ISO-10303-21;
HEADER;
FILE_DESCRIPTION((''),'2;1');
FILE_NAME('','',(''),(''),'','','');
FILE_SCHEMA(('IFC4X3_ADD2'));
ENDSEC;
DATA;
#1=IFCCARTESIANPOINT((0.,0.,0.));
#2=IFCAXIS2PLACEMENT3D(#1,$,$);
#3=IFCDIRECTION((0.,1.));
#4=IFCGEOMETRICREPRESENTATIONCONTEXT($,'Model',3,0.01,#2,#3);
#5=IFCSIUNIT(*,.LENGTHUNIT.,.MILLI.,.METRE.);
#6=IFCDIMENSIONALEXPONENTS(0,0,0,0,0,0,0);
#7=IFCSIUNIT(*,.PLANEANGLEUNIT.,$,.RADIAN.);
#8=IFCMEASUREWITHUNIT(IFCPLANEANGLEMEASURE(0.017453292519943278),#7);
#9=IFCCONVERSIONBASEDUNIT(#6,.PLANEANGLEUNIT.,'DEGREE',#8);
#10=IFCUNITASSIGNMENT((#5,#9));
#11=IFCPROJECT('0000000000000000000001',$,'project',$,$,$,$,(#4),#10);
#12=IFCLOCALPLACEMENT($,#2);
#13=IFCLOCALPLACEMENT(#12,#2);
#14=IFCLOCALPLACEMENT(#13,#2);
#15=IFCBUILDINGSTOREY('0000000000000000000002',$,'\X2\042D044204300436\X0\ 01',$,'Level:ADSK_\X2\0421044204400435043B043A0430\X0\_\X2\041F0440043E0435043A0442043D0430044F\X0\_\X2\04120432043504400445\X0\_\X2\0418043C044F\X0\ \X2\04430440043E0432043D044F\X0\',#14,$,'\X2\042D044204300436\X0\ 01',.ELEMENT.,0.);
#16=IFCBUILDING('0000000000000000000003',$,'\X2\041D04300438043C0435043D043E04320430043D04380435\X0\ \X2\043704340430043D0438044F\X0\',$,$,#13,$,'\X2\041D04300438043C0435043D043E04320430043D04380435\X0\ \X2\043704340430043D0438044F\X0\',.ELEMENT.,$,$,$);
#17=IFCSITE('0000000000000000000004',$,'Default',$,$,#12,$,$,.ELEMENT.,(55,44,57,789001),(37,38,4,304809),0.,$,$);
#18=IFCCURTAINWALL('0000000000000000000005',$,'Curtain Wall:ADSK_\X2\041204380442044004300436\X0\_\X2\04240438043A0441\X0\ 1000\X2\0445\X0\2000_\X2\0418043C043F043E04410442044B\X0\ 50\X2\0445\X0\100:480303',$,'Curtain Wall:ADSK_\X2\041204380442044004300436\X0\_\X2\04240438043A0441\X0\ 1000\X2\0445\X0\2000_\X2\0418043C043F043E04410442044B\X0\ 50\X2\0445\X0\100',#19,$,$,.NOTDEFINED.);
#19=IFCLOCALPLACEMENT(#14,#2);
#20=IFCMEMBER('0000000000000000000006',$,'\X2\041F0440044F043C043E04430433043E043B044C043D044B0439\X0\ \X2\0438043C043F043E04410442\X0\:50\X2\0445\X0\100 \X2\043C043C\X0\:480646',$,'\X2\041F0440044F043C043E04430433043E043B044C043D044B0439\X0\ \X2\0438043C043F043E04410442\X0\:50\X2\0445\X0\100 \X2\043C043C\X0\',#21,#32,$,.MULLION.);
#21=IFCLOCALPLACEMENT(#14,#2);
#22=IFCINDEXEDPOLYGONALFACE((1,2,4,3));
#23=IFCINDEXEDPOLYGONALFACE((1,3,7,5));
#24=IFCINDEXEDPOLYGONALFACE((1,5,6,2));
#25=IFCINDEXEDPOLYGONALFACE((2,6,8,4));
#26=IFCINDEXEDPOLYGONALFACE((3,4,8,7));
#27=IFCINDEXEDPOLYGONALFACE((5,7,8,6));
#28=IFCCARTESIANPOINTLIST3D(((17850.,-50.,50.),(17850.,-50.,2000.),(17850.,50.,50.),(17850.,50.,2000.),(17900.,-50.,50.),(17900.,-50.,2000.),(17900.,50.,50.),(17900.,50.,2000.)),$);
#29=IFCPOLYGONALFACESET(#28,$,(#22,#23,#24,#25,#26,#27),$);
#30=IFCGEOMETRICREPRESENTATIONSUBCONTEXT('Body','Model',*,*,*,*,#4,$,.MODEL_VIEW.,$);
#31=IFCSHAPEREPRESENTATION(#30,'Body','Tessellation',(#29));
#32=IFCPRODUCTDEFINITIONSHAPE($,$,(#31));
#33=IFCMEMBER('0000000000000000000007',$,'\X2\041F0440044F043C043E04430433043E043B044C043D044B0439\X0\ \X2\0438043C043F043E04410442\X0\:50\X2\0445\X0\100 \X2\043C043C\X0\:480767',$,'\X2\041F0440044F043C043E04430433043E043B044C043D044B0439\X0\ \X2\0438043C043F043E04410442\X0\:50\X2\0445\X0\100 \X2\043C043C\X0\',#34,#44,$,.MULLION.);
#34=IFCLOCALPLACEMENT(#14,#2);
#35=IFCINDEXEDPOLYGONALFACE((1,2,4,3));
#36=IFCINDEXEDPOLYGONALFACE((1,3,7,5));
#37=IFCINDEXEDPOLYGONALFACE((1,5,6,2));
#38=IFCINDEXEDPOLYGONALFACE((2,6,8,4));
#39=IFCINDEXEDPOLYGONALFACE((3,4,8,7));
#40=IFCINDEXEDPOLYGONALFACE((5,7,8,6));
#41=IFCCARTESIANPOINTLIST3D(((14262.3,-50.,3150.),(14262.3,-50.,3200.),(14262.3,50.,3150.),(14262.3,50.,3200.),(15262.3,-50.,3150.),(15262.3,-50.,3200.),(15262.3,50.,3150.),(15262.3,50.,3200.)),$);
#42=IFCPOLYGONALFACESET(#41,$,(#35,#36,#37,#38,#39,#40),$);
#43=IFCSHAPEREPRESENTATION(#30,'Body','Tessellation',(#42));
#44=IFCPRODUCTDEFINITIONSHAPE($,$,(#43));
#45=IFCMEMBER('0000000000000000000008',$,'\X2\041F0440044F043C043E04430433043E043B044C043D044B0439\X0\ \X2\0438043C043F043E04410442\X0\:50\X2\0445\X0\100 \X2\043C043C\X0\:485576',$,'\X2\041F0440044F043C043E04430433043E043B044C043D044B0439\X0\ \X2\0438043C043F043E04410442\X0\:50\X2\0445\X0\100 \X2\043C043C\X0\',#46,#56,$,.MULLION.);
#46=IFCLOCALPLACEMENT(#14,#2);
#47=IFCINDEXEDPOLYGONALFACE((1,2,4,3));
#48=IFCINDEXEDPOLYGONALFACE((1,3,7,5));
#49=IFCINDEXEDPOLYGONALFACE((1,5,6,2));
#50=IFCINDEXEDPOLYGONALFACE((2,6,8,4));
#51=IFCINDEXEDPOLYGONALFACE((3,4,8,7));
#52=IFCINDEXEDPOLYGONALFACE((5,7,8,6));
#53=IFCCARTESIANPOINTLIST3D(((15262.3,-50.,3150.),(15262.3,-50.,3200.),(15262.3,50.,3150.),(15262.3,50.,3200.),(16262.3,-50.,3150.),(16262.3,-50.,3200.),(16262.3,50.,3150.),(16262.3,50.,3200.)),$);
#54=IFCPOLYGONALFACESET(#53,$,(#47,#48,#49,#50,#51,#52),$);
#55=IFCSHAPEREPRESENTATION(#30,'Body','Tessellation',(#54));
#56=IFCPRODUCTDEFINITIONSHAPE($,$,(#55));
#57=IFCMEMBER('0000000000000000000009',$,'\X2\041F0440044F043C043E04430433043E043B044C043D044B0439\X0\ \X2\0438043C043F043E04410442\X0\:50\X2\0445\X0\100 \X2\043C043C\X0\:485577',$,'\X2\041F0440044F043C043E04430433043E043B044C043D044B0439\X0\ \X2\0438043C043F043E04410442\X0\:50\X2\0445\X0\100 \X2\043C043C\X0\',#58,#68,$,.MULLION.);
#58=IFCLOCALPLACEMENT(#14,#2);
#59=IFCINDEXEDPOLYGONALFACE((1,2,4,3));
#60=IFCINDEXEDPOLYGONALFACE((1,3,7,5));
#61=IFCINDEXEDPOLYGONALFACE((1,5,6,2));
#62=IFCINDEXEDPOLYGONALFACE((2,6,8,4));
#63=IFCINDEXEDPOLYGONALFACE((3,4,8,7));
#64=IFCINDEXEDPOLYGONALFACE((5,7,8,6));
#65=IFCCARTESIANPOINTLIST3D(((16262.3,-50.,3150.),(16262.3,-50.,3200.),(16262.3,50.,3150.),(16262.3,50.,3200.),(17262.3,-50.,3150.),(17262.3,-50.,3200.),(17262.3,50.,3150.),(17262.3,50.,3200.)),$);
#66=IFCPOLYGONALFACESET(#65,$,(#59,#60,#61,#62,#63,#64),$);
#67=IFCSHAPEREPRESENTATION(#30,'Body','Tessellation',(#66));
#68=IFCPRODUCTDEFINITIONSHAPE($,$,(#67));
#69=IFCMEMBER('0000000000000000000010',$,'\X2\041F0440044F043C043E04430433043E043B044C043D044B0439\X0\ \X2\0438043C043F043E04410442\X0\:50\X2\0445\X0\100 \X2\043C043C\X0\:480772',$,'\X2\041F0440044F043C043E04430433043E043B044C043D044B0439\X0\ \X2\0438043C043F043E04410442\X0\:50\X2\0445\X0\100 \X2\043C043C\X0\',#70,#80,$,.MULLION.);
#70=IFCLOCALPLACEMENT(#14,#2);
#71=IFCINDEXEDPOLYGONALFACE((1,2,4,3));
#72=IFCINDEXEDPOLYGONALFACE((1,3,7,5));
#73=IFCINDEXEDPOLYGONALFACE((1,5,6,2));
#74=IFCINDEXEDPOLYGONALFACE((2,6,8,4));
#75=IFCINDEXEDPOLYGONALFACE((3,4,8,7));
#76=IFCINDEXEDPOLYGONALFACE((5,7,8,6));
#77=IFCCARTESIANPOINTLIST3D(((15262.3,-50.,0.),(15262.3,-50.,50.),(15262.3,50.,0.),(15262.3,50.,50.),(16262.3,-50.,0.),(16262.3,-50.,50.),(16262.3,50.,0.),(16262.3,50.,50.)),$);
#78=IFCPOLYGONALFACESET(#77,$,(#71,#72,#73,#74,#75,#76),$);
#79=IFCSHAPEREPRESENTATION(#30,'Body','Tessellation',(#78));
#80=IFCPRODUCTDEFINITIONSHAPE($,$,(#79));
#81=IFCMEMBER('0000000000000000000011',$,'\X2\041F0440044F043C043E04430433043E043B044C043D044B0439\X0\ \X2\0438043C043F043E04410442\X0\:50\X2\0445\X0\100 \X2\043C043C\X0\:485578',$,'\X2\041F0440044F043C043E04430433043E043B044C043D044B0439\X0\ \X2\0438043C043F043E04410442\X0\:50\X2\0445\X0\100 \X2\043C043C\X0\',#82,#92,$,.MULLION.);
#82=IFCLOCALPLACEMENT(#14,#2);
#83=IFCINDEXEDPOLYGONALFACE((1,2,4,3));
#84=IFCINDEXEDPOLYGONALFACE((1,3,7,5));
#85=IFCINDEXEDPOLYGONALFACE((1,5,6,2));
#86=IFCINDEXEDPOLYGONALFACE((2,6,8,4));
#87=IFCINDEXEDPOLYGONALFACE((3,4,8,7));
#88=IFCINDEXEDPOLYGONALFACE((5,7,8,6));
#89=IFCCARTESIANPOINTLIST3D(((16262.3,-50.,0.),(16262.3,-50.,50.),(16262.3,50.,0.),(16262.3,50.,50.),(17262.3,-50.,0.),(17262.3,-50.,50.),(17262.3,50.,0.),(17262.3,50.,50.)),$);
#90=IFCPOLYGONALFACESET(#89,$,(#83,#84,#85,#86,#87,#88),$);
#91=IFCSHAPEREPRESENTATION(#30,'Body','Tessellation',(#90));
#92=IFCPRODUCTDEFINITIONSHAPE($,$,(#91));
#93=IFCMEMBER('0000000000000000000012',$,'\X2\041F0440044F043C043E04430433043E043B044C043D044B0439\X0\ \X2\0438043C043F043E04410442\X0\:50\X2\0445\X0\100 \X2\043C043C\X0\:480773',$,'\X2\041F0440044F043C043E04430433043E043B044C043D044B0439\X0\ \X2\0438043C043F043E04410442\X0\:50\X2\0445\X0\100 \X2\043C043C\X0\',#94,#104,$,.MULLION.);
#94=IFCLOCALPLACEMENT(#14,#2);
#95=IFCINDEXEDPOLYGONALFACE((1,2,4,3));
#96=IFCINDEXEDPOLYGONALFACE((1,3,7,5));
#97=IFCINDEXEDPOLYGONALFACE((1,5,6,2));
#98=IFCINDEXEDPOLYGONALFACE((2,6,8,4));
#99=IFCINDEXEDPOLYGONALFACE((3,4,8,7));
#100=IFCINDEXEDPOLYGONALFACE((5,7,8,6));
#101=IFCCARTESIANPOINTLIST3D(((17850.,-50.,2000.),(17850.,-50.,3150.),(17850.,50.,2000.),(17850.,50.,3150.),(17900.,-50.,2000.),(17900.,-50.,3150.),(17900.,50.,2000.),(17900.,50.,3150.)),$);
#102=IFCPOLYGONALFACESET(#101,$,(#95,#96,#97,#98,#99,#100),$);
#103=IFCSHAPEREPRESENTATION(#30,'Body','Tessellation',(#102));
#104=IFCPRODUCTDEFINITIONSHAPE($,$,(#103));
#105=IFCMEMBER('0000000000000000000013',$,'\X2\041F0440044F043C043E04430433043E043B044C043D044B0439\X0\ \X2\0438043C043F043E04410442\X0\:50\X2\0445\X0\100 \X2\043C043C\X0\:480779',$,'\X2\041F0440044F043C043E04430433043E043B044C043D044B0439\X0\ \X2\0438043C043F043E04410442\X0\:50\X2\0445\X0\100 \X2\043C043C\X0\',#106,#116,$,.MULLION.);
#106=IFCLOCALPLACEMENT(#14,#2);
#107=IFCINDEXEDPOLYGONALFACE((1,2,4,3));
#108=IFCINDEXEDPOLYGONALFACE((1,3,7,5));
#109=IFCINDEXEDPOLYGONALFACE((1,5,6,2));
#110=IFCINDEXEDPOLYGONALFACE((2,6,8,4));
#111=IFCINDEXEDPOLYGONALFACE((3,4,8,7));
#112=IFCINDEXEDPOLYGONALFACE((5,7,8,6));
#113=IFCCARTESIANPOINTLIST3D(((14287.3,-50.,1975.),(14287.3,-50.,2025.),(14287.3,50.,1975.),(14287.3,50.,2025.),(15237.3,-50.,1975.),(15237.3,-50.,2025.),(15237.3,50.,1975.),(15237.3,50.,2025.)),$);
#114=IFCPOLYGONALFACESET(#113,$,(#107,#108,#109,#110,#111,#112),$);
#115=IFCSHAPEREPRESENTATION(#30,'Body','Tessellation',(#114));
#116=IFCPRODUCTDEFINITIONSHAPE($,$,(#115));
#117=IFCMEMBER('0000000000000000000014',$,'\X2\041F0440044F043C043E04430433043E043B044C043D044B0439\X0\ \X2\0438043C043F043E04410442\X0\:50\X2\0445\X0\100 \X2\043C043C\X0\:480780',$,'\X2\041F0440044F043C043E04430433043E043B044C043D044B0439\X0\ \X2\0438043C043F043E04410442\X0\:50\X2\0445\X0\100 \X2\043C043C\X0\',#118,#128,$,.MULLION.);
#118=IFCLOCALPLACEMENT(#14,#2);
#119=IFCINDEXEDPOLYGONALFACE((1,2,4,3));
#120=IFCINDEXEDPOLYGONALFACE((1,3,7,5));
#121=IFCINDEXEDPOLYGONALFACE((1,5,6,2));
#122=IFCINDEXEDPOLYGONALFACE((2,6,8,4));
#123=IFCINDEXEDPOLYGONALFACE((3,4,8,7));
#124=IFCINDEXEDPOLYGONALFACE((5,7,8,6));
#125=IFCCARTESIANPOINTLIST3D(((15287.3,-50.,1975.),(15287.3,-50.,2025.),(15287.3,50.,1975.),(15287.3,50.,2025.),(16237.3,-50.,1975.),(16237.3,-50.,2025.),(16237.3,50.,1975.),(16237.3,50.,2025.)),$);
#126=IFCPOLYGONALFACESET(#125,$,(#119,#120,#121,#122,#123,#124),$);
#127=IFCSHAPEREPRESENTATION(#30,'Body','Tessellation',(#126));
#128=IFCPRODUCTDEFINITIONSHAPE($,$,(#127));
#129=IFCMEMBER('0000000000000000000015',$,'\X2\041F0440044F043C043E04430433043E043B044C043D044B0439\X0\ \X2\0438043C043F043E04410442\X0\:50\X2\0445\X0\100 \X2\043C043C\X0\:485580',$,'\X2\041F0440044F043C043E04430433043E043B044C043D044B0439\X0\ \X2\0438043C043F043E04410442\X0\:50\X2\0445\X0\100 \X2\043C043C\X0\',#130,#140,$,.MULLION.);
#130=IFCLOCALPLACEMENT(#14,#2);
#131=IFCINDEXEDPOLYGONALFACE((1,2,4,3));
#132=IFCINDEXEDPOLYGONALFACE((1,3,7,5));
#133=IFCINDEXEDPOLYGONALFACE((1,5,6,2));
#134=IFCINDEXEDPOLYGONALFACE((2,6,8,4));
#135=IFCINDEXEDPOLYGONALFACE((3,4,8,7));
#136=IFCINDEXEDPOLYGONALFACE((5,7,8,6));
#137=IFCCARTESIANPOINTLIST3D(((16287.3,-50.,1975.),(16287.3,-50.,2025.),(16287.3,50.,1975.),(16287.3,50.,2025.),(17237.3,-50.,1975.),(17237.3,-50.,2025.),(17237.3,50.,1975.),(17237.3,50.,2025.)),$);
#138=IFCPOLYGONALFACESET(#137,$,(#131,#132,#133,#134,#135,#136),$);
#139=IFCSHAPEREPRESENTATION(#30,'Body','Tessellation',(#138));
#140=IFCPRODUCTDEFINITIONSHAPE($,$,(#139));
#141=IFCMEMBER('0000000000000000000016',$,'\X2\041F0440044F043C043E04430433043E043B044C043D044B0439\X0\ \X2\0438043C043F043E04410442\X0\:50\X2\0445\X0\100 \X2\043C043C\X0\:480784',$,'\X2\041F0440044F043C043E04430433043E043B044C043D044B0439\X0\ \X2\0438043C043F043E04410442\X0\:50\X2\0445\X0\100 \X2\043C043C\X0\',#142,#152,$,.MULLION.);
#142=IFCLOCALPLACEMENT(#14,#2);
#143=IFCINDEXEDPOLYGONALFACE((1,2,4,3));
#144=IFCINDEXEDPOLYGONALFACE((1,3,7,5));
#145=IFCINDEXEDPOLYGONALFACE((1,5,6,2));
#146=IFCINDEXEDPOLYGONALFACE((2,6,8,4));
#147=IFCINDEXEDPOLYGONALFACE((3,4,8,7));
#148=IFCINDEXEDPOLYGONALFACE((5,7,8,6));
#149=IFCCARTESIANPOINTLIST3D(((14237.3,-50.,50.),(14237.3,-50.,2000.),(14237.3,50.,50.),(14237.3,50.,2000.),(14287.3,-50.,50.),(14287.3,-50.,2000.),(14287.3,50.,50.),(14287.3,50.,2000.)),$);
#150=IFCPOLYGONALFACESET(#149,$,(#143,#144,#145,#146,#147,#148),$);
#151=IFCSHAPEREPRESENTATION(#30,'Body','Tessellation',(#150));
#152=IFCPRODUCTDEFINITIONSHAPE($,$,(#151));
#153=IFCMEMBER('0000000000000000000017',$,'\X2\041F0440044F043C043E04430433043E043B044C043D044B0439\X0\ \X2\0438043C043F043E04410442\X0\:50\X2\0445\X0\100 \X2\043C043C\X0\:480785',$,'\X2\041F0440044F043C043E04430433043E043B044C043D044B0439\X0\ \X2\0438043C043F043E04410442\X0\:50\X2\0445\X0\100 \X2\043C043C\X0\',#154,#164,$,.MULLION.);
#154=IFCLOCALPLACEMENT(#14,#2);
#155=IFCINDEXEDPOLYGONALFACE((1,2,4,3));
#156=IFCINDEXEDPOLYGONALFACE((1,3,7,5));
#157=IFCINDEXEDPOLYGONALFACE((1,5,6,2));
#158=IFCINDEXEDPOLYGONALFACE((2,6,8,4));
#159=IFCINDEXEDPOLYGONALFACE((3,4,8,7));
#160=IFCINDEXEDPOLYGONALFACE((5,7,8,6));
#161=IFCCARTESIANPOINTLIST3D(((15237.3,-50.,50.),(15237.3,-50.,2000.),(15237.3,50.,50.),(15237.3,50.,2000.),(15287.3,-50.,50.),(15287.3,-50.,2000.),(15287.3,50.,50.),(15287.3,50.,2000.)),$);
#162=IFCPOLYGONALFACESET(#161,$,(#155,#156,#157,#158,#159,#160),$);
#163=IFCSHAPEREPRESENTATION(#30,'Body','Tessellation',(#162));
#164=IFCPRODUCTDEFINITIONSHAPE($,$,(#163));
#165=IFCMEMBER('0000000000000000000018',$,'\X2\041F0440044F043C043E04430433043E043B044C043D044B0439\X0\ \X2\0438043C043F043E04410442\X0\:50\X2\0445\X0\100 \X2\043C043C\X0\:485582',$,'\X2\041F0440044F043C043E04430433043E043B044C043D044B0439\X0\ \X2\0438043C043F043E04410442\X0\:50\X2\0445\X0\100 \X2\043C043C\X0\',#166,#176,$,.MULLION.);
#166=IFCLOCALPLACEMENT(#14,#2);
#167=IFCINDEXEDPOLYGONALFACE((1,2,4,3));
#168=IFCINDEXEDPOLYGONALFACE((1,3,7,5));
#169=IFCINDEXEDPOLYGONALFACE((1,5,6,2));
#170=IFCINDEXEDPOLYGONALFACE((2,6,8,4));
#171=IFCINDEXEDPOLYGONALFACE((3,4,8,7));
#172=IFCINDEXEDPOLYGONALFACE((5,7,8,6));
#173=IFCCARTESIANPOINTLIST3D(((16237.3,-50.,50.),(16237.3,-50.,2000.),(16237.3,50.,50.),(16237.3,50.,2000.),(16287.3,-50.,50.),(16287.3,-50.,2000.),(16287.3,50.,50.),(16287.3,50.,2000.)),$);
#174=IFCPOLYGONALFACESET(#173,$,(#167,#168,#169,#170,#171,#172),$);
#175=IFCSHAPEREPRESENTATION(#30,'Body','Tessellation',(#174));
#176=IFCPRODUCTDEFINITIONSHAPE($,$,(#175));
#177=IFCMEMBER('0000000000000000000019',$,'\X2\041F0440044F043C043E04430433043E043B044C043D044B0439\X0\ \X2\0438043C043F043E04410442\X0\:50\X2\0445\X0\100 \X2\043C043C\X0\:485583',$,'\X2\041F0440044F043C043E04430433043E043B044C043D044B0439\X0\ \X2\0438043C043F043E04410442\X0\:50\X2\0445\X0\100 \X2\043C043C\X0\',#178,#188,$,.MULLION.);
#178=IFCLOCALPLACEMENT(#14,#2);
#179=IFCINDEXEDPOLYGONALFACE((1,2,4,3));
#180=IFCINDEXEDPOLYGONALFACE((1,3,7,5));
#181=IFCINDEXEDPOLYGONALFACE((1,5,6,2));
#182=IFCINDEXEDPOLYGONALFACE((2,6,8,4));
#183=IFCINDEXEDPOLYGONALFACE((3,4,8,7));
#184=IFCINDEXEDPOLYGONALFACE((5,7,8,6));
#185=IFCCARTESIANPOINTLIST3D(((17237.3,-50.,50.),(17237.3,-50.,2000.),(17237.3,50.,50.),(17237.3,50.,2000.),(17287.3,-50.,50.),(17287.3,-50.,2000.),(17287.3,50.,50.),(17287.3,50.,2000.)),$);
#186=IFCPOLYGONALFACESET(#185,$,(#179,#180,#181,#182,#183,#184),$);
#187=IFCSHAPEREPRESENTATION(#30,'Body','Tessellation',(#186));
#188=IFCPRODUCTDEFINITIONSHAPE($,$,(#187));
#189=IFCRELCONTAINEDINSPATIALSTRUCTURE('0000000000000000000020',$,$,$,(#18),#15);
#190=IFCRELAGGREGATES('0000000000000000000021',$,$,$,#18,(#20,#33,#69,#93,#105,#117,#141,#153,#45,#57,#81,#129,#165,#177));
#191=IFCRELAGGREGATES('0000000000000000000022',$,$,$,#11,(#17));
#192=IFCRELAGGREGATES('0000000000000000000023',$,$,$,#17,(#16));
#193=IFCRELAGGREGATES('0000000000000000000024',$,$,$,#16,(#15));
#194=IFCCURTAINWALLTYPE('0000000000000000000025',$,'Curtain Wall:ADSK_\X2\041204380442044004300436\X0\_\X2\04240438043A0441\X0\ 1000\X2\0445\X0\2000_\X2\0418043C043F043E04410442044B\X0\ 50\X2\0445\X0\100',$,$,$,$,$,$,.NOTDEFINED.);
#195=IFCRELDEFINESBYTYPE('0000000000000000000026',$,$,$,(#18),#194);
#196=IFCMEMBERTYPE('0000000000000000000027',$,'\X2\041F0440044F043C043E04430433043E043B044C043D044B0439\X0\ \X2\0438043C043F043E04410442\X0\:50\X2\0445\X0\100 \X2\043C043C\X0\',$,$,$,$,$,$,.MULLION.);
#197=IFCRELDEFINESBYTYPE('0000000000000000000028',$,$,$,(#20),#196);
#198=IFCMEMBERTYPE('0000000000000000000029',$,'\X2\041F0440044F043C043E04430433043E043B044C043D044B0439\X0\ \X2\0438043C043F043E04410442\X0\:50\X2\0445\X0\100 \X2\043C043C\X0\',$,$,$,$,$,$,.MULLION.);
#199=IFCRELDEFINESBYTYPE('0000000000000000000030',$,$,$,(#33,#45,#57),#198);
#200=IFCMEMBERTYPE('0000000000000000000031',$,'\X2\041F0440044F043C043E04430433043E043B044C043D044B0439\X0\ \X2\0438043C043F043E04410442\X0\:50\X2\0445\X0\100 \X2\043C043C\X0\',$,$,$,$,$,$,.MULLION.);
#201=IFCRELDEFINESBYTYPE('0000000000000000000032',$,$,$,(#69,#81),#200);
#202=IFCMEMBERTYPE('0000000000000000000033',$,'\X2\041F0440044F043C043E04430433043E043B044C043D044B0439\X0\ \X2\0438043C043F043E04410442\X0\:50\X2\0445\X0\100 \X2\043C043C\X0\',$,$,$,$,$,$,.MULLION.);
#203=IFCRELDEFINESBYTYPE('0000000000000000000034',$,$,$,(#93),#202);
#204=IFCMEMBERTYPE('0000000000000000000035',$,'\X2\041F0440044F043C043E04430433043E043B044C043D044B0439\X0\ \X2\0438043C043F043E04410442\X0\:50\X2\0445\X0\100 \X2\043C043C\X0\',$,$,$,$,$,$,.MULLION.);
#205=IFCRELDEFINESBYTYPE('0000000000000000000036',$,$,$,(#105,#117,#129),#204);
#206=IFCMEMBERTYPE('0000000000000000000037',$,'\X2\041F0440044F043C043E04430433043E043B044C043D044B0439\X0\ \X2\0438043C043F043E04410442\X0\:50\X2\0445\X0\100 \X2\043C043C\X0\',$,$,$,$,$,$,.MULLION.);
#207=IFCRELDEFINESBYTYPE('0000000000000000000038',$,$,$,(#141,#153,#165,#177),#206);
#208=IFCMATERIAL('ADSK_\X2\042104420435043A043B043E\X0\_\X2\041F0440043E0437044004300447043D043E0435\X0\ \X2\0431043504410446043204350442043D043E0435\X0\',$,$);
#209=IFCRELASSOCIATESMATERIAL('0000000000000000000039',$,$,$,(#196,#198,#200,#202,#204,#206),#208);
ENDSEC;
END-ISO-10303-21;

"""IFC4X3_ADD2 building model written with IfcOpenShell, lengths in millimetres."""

from ifc_helpers import new_model, entity, si_unit, converted_unit, direction, frame, frame_2d, origin, place, context, subcontext, project, spatial, rectangle, extrude, source, transform, mapped, material, material_profile, profile_set, type_object, type_shapes, element, aggregate, save


model = new_model("IFC4X3_ADD2")

# Units and contexts
model_context = context("Model", 3, precision=0.01, world=origin(), true_north=direction((0.0, 1.0)))
body_context = subcontext(model_context, "Body", "Model", "MODEL_VIEW")
ifc_project = project(units=[si_unit("LENGTHUNIT", "METRE", prefix="MILLI"), converted_unit("PLANEANGLEUNIT", "DEGREE", entity("IfcPlaneAngleMeasure", 0.017453292519943278), si_unit("PLANEANGLEUNIT", "RADIAN"), dimensions=[0, 0, 0, 0, 0, 0, 0])], contexts=[model_context])

# Site, building, storey
site_placement = place(None, origin())
site = spatial("IfcSite", under=ifc_project, at=site_placement, Name="Default", CompositionType="ELEMENT", RefLatitude=(55, 44, 57, 789001), RefLongitude=(37, 38, 4, 304809), RefElevation=0.0)
building_placement = place(site_placement, origin())
building = spatial("IfcBuilding", under=site, at=building_placement, Name="Наименование здания", LongName="Наименование здания", CompositionType="ELEMENT")
storey_placement = place(building_placement, origin())
storey = spatial("IfcBuildingStorey", under=building, at=storey_placement, Name="Этаж 01", ObjectType="Level:ADSK_Стрелка_Проектная_Вверх_Имя уровня", LongName="Этаж 01", CompositionType="ELEMENT", Elevation=0.0)

# Curtain wall, members
curtain_wall_type = type_object("IfcCurtainWallType", Name="Curtain Wall:ADSK_Витраж_Фикс 1000х2000_Импосты 50х100", PredefinedType="NOTDEFINED")
curtain_wall_placement = place(storey_placement, origin())
curtain_wall = element("IfcCurtainWall", 1, at=curtain_wall_placement, inside=storey, type_object=curtain_wall_type, Name="Curtain Wall:ADSK_Витраж_Фикс 1000х2000_Импосты 50х100:480303", ObjectType="Curtain Wall:ADSK_Витраж_Фикс 1000х2000_Импосты 50х100", PredefinedType="NOTDEFINED")
ifc_material_1 = material(Name="ADSK_Стекло_Прозрачное бесцветное")
ifc_material_profile = material_profile(ifc_material_1, rectangle(XDim=50.0, YDim=100.0, at=frame_2d((0.0, 0.0), x_axis=(1.0, 0.0))), Name="50х100 мм")
ifc_profile_set = profile_set([ifc_material_profile], Name="50х100 мм")
member_type_1 = type_object("IfcMemberType", Name="Прямоугольный импост:50х100 мм", PredefinedType="MULLION", material=ifc_profile_set)
shared_shape_1 = source(origin(), body_context, "Body", "SweptSolid", [
    extrude(rectangle(XDim=50.0, YDim=100.0, at=frame_2d((0.0, 0.0), x_axis=(1.0, 0.0))), frame((-25.0, 0.0, -1950.0), z_axis=(0.0, 0.0, 1.0), x_axis=(-1.0, 0.0, 0.0)), (0.0, 0.0, 1.0), 1950.0),
])
type_shapes(member_type_1, [shared_shape_1])
member_1_placement = place(curtain_wall_placement, frame((17900.0, 0.0, 50.0), z_axis=(0.0, 0.0, -1.0), x_axis=(1.0, 0.0, 0.0)))
member_1 = element("IfcMember", 2, at=member_1_placement, type_object=member_type_1, Name="Прямоугольный импост:50х100 мм:480646", ObjectType="Прямоугольный импост:50х100 мм", PredefinedType="MULLION", context=body_context, shape_type="MappedRepresentation", body=[
    mapped(shared_shape_1, transform((0.0, 0.0, 0.0), scale=1.0)),
])
member_type_2 = type_object("IfcMemberType", Name="Прямоугольный импост:50х100 мм", PredefinedType="MULLION", material=ifc_profile_set)
shared_shape_2 = source(origin(), body_context, "Body", "SweptSolid", [
    extrude(rectangle(XDim=50.0, YDim=100.0, at=frame_2d((0.0, 0.0), x_axis=(1.0, 0.0))), frame((-25.0, 0.0, -1000.0), z_axis=(0.0, 0.0, 1.0), x_axis=(-1.0, 0.0, 0.0)), (0.0, 0.0, 1.0), 1000.0),
])
type_shapes(member_type_2, [shared_shape_2])
member_2_placement = place(curtain_wall_placement, frame((15262.3, 0.0, 3200.0), z_axis=(1.0, 0.0, 0.0), x_axis=(0.0, 0.0, 1.0)))
member_2 = element("IfcMember", 3, at=member_2_placement, type_object=member_type_2, Name="Прямоугольный импост:50х100 мм:480767", ObjectType="Прямоугольный импост:50х100 мм", PredefinedType="MULLION", context=body_context, shape_type="MappedRepresentation", body=[
    mapped(shared_shape_2, transform((0.0, 0.0, 0.0), scale=1.0)),
])
member_3_placement = place(curtain_wall_placement, frame((16262.3, 0.0, 3200.0), z_axis=(1.0, 0.0, 0.0), x_axis=(0.0, 0.0, 1.0)))
member_3 = element("IfcMember", 4, at=member_3_placement, type_object=member_type_2, Name="Прямоугольный импост:50х100 мм:485576", ObjectType="Прямоугольный импост:50х100 мм", PredefinedType="MULLION", context=body_context, shape_type="MappedRepresentation", body=[
    mapped(shared_shape_2, transform((0.0, 0.0, 0.0), scale=1.0)),
])
member_4_placement = place(curtain_wall_placement, frame((17262.3, 0.0, 3200.0), z_axis=(1.0, 0.0, 0.0), x_axis=(0.0, 0.0, 1.0)))
member_4 = element("IfcMember", 5, at=member_4_placement, type_object=member_type_2, Name="Прямоугольный импост:50х100 мм:485577", ObjectType="Прямоугольный импост:50х100 мм", PredefinedType="MULLION", context=body_context, shape_type="MappedRepresentation", body=[
    mapped(shared_shape_2, transform((0.0, 0.0, 0.0), scale=1.0)),
])
member_type_3 = type_object("IfcMemberType", Name="Прямоугольный импост:50х100 мм", PredefinedType="MULLION", material=ifc_profile_set)
shared_shape_3 = source(origin(), body_context, "Body", "SweptSolid", [
    extrude(rectangle(XDim=50.0, YDim=100.0, at=frame_2d((0.0, 0.0), x_axis=(1.0, 0.0))), frame((-25.0, 0.0, -1000.0), z_axis=(0.0, 0.0, 1.0), x_axis=(-1.0, 0.0, 0.0)), (0.0, 0.0, 1.0), 1000.0),
])
type_shapes(member_type_3, [shared_shape_3])
member_5_placement = place(curtain_wall_placement, frame((15262.3, 0.0, 0.0), z_axis=(-1.0, 0.0, 0.0), x_axis=(0.0, 0.0, -1.0)))
member_5 = element("IfcMember", 6, at=member_5_placement, type_object=member_type_3, Name="Прямоугольный импост:50х100 мм:480772", ObjectType="Прямоугольный импост:50х100 мм", PredefinedType="MULLION", context=body_context, shape_type="MappedRepresentation", body=[
    mapped(shared_shape_3, transform((0.0, 0.0, 0.0), scale=1.0)),
])
member_6_placement = place(curtain_wall_placement, frame((16262.3, 0.0, 0.0), z_axis=(-1.0, 0.0, 0.0), x_axis=(0.0, 0.0, -1.0)))
member_6 = element("IfcMember", 7, at=member_6_placement, type_object=member_type_3, Name="Прямоугольный импост:50х100 мм:485578", ObjectType="Прямоугольный импост:50х100 мм", PredefinedType="MULLION", context=body_context, shape_type="MappedRepresentation", body=[
    mapped(shared_shape_3, transform((0.0, 0.0, 0.0), scale=1.0)),
])
member_type_4 = type_object("IfcMemberType", Name="Прямоугольный импост:50х100 мм", PredefinedType="MULLION", material=ifc_profile_set)
shared_shape_4 = source(origin(), body_context, "Body", "SweptSolid", [
    extrude(rectangle(XDim=50.0, YDim=100.0, at=frame_2d((0.0, 0.0), x_axis=(1.0, 0.0))), frame((-25.0, 0.0, -1150.0), z_axis=(0.0, 0.0, 1.0), x_axis=(-1.0, 0.0, 0.0)), (0.0, 0.0, 1.0), 1150.0),
])
type_shapes(member_type_4, [shared_shape_4])
member_7_placement = place(curtain_wall_placement, frame((17900.0, 0.0, 2000.0), z_axis=(0.0, 0.0, -1.0), x_axis=(1.0, 0.0, 0.0)))
member_7 = element("IfcMember", 8, at=member_7_placement, type_object=member_type_4, Name="Прямоугольный импост:50х100 мм:480773", ObjectType="Прямоугольный импост:50х100 мм", PredefinedType="MULLION", context=body_context, shape_type="MappedRepresentation", body=[
    mapped(shared_shape_4, transform((0.0, 0.0, 0.0), scale=1.0)),
])
member_type_5 = type_object("IfcMemberType", Name="Прямоугольный импост:50х100 мм", PredefinedType="MULLION", material=ifc_profile_set)
shared_shape_5 = source(origin(), body_context, "Body", "SweptSolid", [
    extrude(rectangle(XDim=50.0, YDim=100.0, at=frame_2d((0.0, 0.0), x_axis=(1.0, 0.0))), frame((0.0, 0.0, -950.0), z_axis=(0.0, 0.0, 1.0), x_axis=(-1.0, 0.0, 0.0)), (0.0, 0.0, 1.0), 950.0),
])
type_shapes(member_type_5, [shared_shape_5])
member_8_placement = place(curtain_wall_placement, frame((15237.3, 0.0, 2000.0), z_axis=(1.0, 0.0, 0.0), x_axis=(0.0, 0.0, 1.0)))
member_8 = element("IfcMember", 9, at=member_8_placement, type_object=member_type_5, Name="Прямоугольный импост:50х100 мм:480779", ObjectType="Прямоугольный импост:50х100 мм", PredefinedType="MULLION", context=body_context, shape_type="MappedRepresentation", body=[
    mapped(shared_shape_5, transform((0.0, 0.0, 0.0), scale=1.0)),
])
member_9_placement = place(curtain_wall_placement, frame((16237.3, 0.0, 2000.0), z_axis=(1.0, 0.0, 0.0), x_axis=(0.0, 0.0, 1.0)))
member_9 = element("IfcMember", 10, at=member_9_placement, type_object=member_type_5, Name="Прямоугольный импост:50х100 мм:480780", ObjectType="Прямоугольный импост:50х100 мм", PredefinedType="MULLION", context=body_context, shape_type="MappedRepresentation", body=[
    mapped(shared_shape_5, transform((0.0, 0.0, 0.0), scale=1.0)),
])
member_10_placement = place(curtain_wall_placement, frame((17237.3, 0.0, 2000.0), z_axis=(1.0, 0.0, 0.0), x_axis=(0.0, 0.0, 1.0)))
member_10 = element("IfcMember", 11, at=member_10_placement, type_object=member_type_5, Name="Прямоугольный импост:50х100 мм:485580", ObjectType="Прямоугольный импост:50х100 мм", PredefinedType="MULLION", context=body_context, shape_type="MappedRepresentation", body=[
    mapped(shared_shape_5, transform((0.0, 0.0, 0.0), scale=1.0)),
])
member_type_6 = type_object("IfcMemberType", Name="Прямоугольный импост:50х100 мм", PredefinedType="MULLION", material=ifc_profile_set)
shared_shape_6 = source(origin(), body_context, "Body", "SweptSolid", [
    extrude(rectangle(XDim=50.0, YDim=100.0, at=frame_2d((0.0, 0.0), x_axis=(1.0, 0.0))), frame((0.0, 0.0, -1950.0), z_axis=(0.0, 0.0, 1.0), x_axis=(-1.0, 0.0, 0.0)), (0.0, 0.0, 1.0), 1950.0),
])
type_shapes(member_type_6, [shared_shape_6])
member_11_placement = place(curtain_wall_placement, frame((14262.3, 0.0, 50.0), z_axis=(0.0, 0.0, -1.0), x_axis=(1.0, 0.0, 0.0)))
member_11 = element("IfcMember", 12, at=member_11_placement, type_object=member_type_6, Name="Прямоугольный импост:50х100 мм:480784", ObjectType="Прямоугольный импост:50х100 мм", PredefinedType="MULLION", context=body_context, shape_type="MappedRepresentation", body=[
    mapped(shared_shape_6, transform((0.0, 0.0, 0.0), scale=1.0)),
])
member_12_placement = place(curtain_wall_placement, frame((15262.3, 0.0, 50.0), z_axis=(0.0, 0.0, -1.0), x_axis=(1.0, 0.0, 0.0)))
member_12 = element("IfcMember", 13, at=member_12_placement, type_object=member_type_6, Name="Прямоугольный импост:50х100 мм:480785", ObjectType="Прямоугольный импост:50х100 мм", PredefinedType="MULLION", context=body_context, shape_type="MappedRepresentation", body=[
    mapped(shared_shape_6, transform((0.0, 0.0, 0.0), scale=1.0)),
])
member_13_placement = place(curtain_wall_placement, frame((16262.3, 0.0, 50.0), z_axis=(0.0, 0.0, -1.0), x_axis=(1.0, 0.0, 0.0)))
member_13 = element("IfcMember", 14, at=member_13_placement, type_object=member_type_6, Name="Прямоугольный импост:50х100 мм:485582", ObjectType="Прямоугольный импост:50х100 мм", PredefinedType="MULLION", context=body_context, shape_type="MappedRepresentation", body=[
    mapped(shared_shape_6, transform((0.0, 0.0, 0.0), scale=1.0)),
])
member_14_placement = place(curtain_wall_placement, frame((17262.3, 0.0, 50.0), z_axis=(0.0, 0.0, -1.0), x_axis=(1.0, 0.0, 0.0)))
member_14 = element("IfcMember", 15, at=member_14_placement, type_object=member_type_6, Name="Прямоугольный импост:50х100 мм:485583", ObjectType="Прямоугольный импост:50х100 мм", PredefinedType="MULLION", context=body_context, shape_type="MappedRepresentation", body=[
    mapped(shared_shape_6, transform((0.0, 0.0, 0.0), scale=1.0)),
])
aggregate(curtain_wall, [member_1, member_2, member_5, member_7, member_8, member_9, member_11, member_12, member_3, member_4, member_6, member_10, member_13, member_14])

save(model, "model.ifc")
